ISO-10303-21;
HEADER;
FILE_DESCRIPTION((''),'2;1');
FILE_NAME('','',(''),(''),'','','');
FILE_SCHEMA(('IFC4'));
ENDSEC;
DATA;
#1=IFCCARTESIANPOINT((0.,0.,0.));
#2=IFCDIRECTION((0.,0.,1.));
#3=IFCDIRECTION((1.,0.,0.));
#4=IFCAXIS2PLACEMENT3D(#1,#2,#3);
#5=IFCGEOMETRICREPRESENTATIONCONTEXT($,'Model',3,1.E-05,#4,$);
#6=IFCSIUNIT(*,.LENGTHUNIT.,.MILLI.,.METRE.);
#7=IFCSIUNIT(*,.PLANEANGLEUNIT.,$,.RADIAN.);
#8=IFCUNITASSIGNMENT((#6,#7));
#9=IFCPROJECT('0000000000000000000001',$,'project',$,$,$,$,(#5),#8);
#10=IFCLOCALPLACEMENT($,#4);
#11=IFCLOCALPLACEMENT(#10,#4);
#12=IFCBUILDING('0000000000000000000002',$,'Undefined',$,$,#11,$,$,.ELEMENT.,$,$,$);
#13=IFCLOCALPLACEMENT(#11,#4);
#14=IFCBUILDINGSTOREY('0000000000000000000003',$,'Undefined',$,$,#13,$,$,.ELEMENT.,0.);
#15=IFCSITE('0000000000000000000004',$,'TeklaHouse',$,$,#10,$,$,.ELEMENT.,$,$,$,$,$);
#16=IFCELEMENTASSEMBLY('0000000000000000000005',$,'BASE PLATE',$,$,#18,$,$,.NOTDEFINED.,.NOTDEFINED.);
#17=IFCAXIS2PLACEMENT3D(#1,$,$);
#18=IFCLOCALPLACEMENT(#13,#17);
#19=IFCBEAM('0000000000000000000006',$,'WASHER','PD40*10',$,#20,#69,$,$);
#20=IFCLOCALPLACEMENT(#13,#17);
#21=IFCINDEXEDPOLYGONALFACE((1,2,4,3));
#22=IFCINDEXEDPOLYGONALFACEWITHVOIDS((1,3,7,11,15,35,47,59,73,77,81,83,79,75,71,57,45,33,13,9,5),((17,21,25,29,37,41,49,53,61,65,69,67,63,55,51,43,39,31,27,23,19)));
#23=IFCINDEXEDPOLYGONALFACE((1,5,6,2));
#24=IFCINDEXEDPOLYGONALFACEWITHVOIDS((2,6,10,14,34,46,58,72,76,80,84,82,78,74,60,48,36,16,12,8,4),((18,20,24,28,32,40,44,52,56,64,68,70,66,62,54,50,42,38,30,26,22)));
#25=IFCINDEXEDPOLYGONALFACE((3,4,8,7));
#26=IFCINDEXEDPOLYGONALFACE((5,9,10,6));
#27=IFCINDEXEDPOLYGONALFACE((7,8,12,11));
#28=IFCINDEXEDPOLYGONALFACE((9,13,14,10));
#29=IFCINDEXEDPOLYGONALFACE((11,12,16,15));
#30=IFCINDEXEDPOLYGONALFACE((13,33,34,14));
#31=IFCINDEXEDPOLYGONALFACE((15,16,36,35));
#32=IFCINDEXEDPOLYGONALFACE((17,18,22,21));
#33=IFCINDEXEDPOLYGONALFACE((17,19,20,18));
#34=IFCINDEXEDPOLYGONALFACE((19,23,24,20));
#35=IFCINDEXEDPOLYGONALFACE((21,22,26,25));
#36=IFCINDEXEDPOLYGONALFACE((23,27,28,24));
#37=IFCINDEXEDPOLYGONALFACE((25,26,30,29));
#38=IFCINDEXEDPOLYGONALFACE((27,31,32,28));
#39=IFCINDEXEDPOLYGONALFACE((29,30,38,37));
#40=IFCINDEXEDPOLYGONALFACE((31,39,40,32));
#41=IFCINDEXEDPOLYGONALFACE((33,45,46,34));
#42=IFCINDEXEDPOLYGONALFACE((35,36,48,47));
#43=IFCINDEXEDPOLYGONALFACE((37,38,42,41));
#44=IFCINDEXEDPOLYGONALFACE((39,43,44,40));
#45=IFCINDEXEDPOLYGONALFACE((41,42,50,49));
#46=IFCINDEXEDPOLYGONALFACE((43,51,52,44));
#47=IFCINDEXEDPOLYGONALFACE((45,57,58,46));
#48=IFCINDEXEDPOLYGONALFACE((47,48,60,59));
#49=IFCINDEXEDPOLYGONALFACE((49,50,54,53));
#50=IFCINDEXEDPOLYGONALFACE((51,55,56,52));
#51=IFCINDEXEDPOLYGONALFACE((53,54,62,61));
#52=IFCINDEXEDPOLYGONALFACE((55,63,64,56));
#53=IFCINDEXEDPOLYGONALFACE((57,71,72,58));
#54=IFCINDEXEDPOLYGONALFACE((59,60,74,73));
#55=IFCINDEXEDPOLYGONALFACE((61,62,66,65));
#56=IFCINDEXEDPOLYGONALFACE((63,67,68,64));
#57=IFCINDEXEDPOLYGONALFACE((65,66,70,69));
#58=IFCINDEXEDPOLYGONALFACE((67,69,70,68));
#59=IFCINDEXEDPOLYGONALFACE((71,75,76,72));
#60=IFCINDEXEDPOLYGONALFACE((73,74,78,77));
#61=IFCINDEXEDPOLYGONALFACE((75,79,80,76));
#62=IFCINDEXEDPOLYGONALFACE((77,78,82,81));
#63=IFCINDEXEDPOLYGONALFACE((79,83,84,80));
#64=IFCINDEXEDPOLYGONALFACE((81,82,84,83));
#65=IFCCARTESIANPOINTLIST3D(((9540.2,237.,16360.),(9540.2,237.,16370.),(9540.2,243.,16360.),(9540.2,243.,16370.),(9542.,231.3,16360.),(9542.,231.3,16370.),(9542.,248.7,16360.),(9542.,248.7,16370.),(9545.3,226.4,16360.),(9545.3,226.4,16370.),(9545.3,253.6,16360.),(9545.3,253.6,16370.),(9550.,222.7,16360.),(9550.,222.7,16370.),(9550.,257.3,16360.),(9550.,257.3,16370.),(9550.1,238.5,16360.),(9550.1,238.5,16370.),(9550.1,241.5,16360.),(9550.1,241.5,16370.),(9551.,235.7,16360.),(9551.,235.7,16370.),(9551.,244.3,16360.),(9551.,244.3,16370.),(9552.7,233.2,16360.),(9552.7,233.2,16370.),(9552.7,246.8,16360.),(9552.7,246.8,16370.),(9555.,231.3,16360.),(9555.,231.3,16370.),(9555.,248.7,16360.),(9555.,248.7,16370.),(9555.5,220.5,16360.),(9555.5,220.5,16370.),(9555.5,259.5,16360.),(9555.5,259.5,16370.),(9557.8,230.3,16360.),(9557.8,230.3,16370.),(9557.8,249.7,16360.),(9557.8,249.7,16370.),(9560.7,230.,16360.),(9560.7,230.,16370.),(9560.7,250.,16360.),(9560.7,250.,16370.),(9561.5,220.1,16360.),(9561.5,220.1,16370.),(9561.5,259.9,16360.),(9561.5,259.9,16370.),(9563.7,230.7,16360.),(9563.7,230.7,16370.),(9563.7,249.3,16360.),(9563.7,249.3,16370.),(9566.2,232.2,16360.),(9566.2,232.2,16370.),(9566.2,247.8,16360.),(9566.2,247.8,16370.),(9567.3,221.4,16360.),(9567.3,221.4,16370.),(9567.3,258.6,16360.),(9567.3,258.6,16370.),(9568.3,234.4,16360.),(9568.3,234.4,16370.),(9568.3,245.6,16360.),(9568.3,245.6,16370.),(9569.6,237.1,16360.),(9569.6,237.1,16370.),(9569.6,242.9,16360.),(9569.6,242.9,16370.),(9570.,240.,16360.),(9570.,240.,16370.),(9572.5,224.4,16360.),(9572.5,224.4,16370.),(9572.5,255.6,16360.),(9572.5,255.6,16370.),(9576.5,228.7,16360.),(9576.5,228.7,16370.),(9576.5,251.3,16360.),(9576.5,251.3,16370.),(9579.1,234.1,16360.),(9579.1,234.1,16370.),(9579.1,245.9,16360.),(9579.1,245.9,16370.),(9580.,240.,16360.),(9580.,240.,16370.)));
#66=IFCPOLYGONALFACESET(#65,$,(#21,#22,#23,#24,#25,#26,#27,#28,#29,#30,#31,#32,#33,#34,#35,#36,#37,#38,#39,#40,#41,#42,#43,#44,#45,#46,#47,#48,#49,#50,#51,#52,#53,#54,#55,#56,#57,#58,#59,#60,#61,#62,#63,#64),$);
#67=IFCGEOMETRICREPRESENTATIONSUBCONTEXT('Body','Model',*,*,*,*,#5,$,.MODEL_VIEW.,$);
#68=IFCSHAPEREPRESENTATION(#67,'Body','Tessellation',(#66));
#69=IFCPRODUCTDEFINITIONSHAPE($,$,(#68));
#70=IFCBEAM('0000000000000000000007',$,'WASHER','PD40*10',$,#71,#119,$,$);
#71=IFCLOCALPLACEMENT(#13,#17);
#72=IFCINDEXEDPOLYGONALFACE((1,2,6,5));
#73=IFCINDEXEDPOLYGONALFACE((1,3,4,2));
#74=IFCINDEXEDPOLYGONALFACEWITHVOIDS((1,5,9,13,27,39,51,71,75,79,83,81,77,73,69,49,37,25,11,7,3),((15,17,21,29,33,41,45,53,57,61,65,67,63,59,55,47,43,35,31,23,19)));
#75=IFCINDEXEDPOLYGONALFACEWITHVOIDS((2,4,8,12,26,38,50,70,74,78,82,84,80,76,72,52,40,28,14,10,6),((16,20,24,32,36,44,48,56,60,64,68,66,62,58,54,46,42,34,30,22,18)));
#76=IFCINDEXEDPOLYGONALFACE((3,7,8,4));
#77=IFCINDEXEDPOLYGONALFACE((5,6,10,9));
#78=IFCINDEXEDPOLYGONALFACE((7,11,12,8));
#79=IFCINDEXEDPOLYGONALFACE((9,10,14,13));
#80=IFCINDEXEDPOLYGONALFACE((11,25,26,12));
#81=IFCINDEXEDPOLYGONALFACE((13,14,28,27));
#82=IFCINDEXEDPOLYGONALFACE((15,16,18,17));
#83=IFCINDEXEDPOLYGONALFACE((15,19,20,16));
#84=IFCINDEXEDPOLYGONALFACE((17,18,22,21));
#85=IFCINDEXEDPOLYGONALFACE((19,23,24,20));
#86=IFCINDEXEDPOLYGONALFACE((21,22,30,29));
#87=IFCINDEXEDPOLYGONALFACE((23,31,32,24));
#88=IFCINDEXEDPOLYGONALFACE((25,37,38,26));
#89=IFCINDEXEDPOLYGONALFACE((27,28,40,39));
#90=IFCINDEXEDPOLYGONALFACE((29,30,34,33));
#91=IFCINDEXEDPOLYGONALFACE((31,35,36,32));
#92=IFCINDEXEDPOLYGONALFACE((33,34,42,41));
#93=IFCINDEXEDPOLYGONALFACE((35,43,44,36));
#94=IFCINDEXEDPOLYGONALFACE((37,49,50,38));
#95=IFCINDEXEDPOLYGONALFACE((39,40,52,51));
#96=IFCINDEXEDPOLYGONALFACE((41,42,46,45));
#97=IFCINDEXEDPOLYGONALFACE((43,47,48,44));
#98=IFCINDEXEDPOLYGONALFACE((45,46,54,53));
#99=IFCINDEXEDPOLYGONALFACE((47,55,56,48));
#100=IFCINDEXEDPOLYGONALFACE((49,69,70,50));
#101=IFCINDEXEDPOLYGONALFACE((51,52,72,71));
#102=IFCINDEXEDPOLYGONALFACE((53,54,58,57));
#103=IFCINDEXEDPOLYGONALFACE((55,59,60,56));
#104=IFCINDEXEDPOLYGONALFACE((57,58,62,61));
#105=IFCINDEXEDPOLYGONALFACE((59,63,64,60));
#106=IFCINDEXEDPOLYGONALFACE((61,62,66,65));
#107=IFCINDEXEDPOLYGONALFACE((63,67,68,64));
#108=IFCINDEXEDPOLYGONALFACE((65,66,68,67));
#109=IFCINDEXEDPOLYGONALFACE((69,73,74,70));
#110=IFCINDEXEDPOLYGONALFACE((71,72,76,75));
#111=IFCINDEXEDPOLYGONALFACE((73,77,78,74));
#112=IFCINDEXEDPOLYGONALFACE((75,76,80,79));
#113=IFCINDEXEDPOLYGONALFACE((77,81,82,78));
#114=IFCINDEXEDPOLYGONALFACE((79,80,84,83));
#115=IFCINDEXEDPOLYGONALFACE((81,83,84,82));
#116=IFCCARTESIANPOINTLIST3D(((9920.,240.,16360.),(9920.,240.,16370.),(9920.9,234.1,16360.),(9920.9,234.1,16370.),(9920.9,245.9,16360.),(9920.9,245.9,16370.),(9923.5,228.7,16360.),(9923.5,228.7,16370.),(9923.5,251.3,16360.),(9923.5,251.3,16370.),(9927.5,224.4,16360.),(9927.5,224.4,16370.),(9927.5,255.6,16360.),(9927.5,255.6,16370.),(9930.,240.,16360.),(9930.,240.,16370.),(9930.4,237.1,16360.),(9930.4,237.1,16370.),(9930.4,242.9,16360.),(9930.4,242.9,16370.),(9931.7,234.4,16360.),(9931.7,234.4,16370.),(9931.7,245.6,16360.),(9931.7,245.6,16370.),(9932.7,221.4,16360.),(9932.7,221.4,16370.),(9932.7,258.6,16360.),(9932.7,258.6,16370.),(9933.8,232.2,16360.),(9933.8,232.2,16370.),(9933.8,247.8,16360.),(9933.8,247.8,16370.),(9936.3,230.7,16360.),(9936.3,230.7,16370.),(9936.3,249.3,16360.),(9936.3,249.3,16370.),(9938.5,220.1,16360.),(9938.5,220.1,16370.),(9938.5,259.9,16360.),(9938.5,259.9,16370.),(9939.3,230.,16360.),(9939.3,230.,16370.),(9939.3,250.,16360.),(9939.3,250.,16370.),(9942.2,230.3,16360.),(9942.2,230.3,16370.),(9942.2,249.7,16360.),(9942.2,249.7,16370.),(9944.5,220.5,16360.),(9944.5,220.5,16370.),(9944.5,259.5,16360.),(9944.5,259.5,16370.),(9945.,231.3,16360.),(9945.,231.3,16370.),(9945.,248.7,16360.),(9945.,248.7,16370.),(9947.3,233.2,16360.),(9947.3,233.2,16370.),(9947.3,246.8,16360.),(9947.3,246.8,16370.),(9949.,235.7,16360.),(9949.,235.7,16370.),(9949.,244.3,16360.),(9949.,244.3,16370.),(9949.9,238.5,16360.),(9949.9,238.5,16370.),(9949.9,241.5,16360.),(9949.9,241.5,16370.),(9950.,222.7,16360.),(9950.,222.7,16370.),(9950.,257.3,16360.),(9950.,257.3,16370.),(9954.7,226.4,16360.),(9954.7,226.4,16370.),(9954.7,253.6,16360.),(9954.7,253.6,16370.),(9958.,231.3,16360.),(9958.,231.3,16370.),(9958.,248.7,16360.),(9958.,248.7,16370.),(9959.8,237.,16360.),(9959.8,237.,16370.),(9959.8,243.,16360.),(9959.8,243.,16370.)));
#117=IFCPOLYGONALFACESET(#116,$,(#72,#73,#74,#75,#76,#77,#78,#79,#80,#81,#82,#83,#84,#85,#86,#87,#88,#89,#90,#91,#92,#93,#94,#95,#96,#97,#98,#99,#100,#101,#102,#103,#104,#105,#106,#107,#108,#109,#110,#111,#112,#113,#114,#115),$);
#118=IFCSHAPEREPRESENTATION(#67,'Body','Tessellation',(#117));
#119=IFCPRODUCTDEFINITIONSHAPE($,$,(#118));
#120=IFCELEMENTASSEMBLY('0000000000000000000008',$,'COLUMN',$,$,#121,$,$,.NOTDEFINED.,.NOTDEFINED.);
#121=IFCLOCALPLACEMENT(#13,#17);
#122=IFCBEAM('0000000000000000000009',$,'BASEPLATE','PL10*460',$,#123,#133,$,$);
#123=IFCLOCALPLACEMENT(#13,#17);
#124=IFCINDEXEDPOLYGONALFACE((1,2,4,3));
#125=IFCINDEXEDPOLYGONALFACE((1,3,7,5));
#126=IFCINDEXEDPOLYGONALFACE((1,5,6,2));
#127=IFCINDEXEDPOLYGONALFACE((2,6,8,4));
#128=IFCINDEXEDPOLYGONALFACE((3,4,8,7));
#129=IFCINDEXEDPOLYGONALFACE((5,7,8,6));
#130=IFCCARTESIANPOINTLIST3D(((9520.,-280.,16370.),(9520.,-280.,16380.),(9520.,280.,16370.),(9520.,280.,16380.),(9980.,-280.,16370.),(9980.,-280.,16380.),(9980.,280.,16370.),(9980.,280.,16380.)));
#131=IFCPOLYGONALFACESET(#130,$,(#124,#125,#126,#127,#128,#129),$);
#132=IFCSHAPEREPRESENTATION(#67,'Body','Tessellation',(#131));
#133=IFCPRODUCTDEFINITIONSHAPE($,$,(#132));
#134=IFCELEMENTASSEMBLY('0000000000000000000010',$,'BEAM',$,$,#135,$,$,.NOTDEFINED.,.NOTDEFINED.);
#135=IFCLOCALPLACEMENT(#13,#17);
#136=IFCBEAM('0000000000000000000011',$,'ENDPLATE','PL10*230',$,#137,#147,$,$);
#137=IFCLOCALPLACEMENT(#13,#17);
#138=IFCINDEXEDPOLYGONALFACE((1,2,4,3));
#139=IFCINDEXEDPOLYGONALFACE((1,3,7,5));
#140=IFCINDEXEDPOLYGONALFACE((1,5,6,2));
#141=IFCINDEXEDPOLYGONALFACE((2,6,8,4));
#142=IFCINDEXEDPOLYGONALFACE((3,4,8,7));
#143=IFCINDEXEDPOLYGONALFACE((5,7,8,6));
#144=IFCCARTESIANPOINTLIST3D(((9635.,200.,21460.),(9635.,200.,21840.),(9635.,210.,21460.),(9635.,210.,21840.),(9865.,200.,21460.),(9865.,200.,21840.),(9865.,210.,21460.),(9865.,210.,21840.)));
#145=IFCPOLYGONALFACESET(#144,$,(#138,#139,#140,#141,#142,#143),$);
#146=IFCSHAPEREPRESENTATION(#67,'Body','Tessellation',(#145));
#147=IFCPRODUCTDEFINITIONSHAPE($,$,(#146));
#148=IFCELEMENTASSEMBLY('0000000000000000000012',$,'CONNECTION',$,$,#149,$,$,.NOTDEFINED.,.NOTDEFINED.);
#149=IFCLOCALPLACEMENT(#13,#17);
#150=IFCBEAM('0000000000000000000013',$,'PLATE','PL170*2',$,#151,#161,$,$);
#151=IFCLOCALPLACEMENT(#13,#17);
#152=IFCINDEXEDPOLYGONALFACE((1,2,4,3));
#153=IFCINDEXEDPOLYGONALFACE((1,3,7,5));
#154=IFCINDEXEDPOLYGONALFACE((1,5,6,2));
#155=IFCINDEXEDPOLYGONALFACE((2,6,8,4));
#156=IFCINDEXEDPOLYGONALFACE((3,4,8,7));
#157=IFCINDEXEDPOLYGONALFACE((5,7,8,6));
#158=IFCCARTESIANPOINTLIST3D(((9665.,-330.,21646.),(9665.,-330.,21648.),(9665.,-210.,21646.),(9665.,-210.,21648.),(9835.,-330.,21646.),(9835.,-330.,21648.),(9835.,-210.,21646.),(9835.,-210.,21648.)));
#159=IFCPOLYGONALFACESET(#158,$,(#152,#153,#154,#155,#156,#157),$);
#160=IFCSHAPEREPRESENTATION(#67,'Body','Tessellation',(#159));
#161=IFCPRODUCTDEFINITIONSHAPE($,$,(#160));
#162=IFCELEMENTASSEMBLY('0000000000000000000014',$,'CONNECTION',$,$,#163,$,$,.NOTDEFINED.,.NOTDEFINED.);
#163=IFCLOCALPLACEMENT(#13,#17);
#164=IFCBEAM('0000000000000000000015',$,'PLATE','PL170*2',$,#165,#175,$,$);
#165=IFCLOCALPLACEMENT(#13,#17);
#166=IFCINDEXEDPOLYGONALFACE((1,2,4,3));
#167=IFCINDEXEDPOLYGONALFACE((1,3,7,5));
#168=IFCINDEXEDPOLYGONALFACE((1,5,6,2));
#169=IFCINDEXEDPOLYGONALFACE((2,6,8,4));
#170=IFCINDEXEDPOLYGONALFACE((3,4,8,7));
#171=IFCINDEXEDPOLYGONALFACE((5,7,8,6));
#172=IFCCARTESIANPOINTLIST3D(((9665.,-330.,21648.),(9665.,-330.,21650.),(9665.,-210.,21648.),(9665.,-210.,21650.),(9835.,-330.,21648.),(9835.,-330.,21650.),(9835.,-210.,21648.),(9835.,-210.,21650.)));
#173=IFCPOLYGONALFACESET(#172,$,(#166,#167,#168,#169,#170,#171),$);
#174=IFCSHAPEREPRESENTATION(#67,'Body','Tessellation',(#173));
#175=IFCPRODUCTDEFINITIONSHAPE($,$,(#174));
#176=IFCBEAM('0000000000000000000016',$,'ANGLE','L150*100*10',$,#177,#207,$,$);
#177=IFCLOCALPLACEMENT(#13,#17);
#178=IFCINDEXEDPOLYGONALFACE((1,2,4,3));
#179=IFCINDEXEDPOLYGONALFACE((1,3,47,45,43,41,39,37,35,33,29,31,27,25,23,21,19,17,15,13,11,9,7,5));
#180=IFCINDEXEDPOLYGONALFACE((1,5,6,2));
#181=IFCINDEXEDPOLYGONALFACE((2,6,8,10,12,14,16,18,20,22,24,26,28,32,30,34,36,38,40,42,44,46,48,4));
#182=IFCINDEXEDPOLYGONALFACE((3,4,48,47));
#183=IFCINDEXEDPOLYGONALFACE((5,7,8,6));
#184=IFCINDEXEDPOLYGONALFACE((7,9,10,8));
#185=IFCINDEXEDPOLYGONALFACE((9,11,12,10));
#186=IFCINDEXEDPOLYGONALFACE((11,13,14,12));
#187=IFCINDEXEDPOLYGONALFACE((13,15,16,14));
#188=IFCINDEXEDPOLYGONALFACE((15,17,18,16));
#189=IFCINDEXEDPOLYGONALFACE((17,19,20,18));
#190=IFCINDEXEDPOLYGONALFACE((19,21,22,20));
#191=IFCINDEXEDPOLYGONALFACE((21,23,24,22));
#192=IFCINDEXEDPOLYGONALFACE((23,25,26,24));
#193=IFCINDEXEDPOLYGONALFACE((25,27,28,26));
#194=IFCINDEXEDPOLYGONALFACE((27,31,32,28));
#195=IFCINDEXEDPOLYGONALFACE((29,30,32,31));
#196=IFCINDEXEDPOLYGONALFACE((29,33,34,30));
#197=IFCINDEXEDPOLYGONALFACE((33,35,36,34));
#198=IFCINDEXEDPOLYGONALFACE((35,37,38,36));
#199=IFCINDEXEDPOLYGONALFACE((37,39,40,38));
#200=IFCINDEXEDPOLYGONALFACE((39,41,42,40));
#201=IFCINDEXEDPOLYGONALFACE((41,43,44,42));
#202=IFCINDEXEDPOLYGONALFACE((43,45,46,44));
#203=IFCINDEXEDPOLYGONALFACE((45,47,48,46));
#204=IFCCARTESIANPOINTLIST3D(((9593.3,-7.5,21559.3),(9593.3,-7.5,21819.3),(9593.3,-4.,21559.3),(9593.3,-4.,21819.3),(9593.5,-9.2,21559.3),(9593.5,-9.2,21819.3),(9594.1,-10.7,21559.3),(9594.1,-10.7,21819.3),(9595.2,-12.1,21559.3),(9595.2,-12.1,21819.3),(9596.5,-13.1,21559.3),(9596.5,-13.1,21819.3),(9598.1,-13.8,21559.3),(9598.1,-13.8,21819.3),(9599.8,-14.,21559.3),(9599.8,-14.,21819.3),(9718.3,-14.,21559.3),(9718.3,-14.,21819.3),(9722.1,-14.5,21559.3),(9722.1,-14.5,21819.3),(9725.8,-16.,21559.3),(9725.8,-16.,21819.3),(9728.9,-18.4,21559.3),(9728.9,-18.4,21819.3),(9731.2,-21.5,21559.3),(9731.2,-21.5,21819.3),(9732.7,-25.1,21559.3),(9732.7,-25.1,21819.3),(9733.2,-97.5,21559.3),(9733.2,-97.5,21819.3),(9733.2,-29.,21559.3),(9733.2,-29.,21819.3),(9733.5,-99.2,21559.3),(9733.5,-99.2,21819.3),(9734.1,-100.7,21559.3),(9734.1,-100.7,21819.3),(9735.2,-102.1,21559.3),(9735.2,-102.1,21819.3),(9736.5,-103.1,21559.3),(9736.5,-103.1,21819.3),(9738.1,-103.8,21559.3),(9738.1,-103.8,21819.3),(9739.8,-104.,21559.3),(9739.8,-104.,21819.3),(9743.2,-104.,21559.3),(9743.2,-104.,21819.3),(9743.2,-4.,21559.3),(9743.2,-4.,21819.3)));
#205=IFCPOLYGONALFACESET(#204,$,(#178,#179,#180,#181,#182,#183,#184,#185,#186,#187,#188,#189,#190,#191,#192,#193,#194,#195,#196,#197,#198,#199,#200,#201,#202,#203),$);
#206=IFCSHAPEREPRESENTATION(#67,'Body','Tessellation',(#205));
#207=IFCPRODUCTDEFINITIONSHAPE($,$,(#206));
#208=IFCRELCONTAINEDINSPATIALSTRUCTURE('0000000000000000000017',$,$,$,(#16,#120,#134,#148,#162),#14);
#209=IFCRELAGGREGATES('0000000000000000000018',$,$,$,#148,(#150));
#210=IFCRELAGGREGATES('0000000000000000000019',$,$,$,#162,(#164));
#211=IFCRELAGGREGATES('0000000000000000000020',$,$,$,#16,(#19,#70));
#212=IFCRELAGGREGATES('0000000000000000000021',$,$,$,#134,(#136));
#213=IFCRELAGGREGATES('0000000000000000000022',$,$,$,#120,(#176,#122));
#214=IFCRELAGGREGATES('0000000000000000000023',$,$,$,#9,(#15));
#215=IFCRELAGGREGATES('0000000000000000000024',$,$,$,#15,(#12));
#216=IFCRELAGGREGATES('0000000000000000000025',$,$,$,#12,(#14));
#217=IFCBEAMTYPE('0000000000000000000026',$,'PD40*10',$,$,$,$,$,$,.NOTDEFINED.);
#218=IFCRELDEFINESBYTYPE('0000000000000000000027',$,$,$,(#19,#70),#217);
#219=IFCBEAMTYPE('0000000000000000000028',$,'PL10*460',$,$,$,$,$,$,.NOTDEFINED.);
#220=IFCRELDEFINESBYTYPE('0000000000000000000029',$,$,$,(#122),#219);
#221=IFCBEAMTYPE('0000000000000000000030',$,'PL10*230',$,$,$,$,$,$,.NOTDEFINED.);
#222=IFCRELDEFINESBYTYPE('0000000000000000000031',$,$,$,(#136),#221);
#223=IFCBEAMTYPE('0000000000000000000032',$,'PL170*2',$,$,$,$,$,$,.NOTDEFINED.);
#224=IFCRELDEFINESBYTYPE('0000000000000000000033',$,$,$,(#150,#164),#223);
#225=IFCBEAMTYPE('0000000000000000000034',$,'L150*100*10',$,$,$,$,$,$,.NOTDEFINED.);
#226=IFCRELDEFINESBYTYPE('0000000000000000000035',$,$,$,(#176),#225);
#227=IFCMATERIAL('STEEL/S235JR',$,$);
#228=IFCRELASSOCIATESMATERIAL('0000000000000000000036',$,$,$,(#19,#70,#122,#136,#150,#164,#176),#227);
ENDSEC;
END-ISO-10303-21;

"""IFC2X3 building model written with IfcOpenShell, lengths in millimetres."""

from ifc_helpers import new_model, si_unit, frame, origin_with_axes, origin_2d_with_axis, place, context, subcontext, project, spatial, rectangle, hollow_circle, l_section, extrude, material, type_object, element, aggregate, save


model = new_model("IFC2X3")

# Units and contexts
model_context = context("Model", 3, precision=1e-05, world=origin_with_axes())
body_context = subcontext(model_context, "Body", "Model", "MODEL_VIEW")
ifc_project = project(units=[si_unit("LENGTHUNIT", "METRE", prefix="MILLI"), si_unit("PLANEANGLEUNIT", "RADIAN")], contexts=[model_context])

# Site, building, storey
site_placement = place(None, origin_with_axes())
site = spatial("IfcSite", under=ifc_project, at=site_placement, Name="TeklaHouse", CompositionType="ELEMENT")
building_placement = place(site_placement, origin_with_axes())
building = spatial("IfcBuilding", under=site, at=building_placement, Name="Undefined", CompositionType="ELEMENT")
storey_placement = place(building_placement, origin_with_axes())
storey = spatial("IfcBuildingStorey", under=building, at=storey_placement, Name="Undefined", CompositionType="ELEMENT", Elevation=0.0)

# Element assembly, beams
assembly_1_placement = place(storey_placement, origin_with_axes())
assembly_1 = element("IfcElementAssembly", 1, at=assembly_1_placement, inside=storey, Name="BASE PLATE", AssemblyPlace="NOTDEFINED", PredefinedType="NOTDEFINED")
ifc_material_1 = material(Name="STEEL/S235JR")
beam_type_1 = type_object("IfcBeamType", Name="PD40*10", PredefinedType="NOTDEFINED")
beam_1_placement = place(assembly_1_placement, frame((9560.0, 240.0, 16370.0), z_axis=(0.0, 1.0, 0.0), x_axis=(0.0, 0.0, -1.0)))
beam_1 = element("IfcBeam", 2, at=beam_1_placement, type_object=beam_type_1, material=ifc_material_1, Name="WASHER", Description="PD40*10", context=body_context, shape_type="SweptSolid", body=[
    extrude(hollow_circle(Radius=20.0, WallThickness=10.0, at=origin_2d_with_axis()), frame((10.0, 0.0, 0.0), z_axis=(-1.0, 0.0, 0.0), x_axis=(0.0, -1.0, 0.0)), (0.0, 0.0, 1.0), 10.0),
])
beam_2_placement = place(assembly_1_placement, frame((9940.0, 240.0, 16370.0), z_axis=(0.0, -1.0, 0.0), x_axis=(0.0, 0.0, -1.0)))
beam_2 = element("IfcBeam", 3, at=beam_2_placement, type_object=beam_type_1, material=ifc_material_1, Name="WASHER", Description="PD40*10", context=body_context, shape_type="SweptSolid", body=[
    extrude(hollow_circle(Radius=20.0, WallThickness=10.0, at=origin_2d_with_axis()), frame((10.0, 0.0, 0.0), z_axis=(-1.0, 0.0, 0.0), x_axis=(0.0, -1.0, 0.0)), (0.0, 0.0, 1.0), 10.0),
])

# Element assemblies, beams
assembly_2_placement = place(storey_placement, origin_with_axes())
assembly_2 = element("IfcElementAssembly", 4, at=assembly_2_placement, inside=storey, Name="COLUMN", AssemblyPlace="NOTDEFINED", PredefinedType="NOTDEFINED")
beam_type_2 = type_object("IfcBeamType", Name="PL10*460", PredefinedType="NOTDEFINED")
beam_3_placement = place(assembly_2_placement, frame((9750.0, -280.0, 16375.0), z_axis=(-1.0, 0.0, 0.0), x_axis=(0.0, 1.0, 0.0)))
beam_3 = element("IfcBeam", 5, at=beam_3_placement, type_object=beam_type_2, material=ifc_material_1, Name="BASEPLATE", Description="PL10*460", context=body_context, shape_type="SweptSolid", body=[
    extrude(rectangle(XDim=10.0, YDim=460.0, at=origin_2d_with_axis()), frame((560.0, 0.0, 0.0), z_axis=(-1.0, 0.0, 0.0), x_axis=(0.0, -1.0, 0.0)), (0.0, 0.0, 1.0), 560.0),
])
assembly_3_placement = place(storey_placement, origin_with_axes())
assembly_3 = element("IfcElementAssembly", 6, at=assembly_3_placement, inside=storey, Name="BEAM", AssemblyPlace="NOTDEFINED", PredefinedType="NOTDEFINED")
beam_type_3 = type_object("IfcBeamType", Name="PL10*230", PredefinedType="NOTDEFINED")
beam_4_placement = place(assembly_3_placement, frame((9750.0, 205.0, 21460.0), z_axis=(1.0, 0.0, 0.0), x_axis=(0.0, 0.0, 1.0)))
beam_4 = element("IfcBeam", 7, at=beam_4_placement, type_object=beam_type_3, material=ifc_material_1, Name="ENDPLATE", Description="PL10*230", context=body_context, shape_type="SweptSolid", body=[
    extrude(rectangle(XDim=10.0, YDim=230.0, at=origin_2d_with_axis()), frame((380.0, 0.0, 0.0), z_axis=(-1.0, 0.0, 0.0), x_axis=(0.0, -1.0, 0.0)), (0.0, 0.0, 1.0), 380.0),
])
assembly_4_placement = place(storey_placement, origin_with_axes())
assembly_4 = element("IfcElementAssembly", 8, at=assembly_4_placement, inside=storey, Name="CONNECTION", AssemblyPlace="NOTDEFINED", PredefinedType="NOTDEFINED")
beam_type_4 = type_object("IfcBeamType", Name="PL170*2", PredefinedType="NOTDEFINED")
beam_5_placement = place(assembly_4_placement, frame((9750.0, -210.0, 21647.0), z_axis=(-1.0, 0.0, 0.0), x_axis=(0.0, -1.0, 0.0)))
beam_5 = element("IfcBeam", 9, at=beam_5_placement, type_object=beam_type_4, material=ifc_material_1, Name="PLATE", Description="PL170*2", context=body_context, shape_type="SweptSolid", body=[
    extrude(rectangle(XDim=2.0, YDim=170.0, at=origin_2d_with_axis()), frame((120.0, 0.0, 0.0), z_axis=(-1.0, 0.0, 0.0), x_axis=(0.0, -1.0, 0.0)), (0.0, 0.0, 1.0), 120.0),
])
aggregate(assembly_4, [beam_5])
assembly_5_placement = place(storey_placement, origin_with_axes())
assembly_5 = element("IfcElementAssembly", 10, at=assembly_5_placement, inside=storey, Name="CONNECTION", AssemblyPlace="NOTDEFINED", PredefinedType="NOTDEFINED")
beam_6_placement = place(assembly_5_placement, frame((9750.0, -210.0, 21649.0), z_axis=(-1.0, 0.0, 0.0), x_axis=(0.0, -1.0, 0.0)))
beam_6 = element("IfcBeam", 11, at=beam_6_placement, type_object=beam_type_4, material=ifc_material_1, Name="PLATE", Description="PL170*2", context=body_context, shape_type="SweptSolid", body=[
    extrude(rectangle(XDim=2.0, YDim=170.0, at=origin_2d_with_axis()), frame((120.0, 0.0, 0.0), z_axis=(-1.0, 0.0, 0.0), x_axis=(0.0, -1.0, 0.0)), (0.0, 0.0, 1.0), 120.0),
])
aggregate(assembly_5, [beam_6])

# Beam
beam_type_5 = type_object("IfcBeamType", Name="L150*100*10", PredefinedType="NOTDEFINED")
beam_7_placement = place(assembly_2_placement, frame((9668.2, -54.0, 21559.3), z_axis=(-1.0, 0.0, 0.0), x_axis=(0.0, 0.0, 1.0)))
beam_7 = element("IfcBeam", 12, at=beam_7_placement, type_object=beam_type_5, material=ifc_material_1, Name="ANGLE", Description="L150*100*10", context=body_context, shape_type="SweptSolid", body=[
    extrude(l_section(Depth=150.0, Width=100.0, Thickness=10.0, FilletRadius=15.0, EdgeRadius=6.5, at=origin_2d_with_axis()), frame((260.0, 0.0, 0.0), z_axis=(-1.0, 0.0, 0.0), x_axis=(0.0, -1.0, 0.0)), (0.0, 0.0, 1.0), 260.0),
])

aggregate(assembly_1, [beam_1, beam_2])
aggregate(assembly_3, [beam_4])
aggregate(assembly_2, [beam_7, beam_3])

save(model, "model.ifc")
